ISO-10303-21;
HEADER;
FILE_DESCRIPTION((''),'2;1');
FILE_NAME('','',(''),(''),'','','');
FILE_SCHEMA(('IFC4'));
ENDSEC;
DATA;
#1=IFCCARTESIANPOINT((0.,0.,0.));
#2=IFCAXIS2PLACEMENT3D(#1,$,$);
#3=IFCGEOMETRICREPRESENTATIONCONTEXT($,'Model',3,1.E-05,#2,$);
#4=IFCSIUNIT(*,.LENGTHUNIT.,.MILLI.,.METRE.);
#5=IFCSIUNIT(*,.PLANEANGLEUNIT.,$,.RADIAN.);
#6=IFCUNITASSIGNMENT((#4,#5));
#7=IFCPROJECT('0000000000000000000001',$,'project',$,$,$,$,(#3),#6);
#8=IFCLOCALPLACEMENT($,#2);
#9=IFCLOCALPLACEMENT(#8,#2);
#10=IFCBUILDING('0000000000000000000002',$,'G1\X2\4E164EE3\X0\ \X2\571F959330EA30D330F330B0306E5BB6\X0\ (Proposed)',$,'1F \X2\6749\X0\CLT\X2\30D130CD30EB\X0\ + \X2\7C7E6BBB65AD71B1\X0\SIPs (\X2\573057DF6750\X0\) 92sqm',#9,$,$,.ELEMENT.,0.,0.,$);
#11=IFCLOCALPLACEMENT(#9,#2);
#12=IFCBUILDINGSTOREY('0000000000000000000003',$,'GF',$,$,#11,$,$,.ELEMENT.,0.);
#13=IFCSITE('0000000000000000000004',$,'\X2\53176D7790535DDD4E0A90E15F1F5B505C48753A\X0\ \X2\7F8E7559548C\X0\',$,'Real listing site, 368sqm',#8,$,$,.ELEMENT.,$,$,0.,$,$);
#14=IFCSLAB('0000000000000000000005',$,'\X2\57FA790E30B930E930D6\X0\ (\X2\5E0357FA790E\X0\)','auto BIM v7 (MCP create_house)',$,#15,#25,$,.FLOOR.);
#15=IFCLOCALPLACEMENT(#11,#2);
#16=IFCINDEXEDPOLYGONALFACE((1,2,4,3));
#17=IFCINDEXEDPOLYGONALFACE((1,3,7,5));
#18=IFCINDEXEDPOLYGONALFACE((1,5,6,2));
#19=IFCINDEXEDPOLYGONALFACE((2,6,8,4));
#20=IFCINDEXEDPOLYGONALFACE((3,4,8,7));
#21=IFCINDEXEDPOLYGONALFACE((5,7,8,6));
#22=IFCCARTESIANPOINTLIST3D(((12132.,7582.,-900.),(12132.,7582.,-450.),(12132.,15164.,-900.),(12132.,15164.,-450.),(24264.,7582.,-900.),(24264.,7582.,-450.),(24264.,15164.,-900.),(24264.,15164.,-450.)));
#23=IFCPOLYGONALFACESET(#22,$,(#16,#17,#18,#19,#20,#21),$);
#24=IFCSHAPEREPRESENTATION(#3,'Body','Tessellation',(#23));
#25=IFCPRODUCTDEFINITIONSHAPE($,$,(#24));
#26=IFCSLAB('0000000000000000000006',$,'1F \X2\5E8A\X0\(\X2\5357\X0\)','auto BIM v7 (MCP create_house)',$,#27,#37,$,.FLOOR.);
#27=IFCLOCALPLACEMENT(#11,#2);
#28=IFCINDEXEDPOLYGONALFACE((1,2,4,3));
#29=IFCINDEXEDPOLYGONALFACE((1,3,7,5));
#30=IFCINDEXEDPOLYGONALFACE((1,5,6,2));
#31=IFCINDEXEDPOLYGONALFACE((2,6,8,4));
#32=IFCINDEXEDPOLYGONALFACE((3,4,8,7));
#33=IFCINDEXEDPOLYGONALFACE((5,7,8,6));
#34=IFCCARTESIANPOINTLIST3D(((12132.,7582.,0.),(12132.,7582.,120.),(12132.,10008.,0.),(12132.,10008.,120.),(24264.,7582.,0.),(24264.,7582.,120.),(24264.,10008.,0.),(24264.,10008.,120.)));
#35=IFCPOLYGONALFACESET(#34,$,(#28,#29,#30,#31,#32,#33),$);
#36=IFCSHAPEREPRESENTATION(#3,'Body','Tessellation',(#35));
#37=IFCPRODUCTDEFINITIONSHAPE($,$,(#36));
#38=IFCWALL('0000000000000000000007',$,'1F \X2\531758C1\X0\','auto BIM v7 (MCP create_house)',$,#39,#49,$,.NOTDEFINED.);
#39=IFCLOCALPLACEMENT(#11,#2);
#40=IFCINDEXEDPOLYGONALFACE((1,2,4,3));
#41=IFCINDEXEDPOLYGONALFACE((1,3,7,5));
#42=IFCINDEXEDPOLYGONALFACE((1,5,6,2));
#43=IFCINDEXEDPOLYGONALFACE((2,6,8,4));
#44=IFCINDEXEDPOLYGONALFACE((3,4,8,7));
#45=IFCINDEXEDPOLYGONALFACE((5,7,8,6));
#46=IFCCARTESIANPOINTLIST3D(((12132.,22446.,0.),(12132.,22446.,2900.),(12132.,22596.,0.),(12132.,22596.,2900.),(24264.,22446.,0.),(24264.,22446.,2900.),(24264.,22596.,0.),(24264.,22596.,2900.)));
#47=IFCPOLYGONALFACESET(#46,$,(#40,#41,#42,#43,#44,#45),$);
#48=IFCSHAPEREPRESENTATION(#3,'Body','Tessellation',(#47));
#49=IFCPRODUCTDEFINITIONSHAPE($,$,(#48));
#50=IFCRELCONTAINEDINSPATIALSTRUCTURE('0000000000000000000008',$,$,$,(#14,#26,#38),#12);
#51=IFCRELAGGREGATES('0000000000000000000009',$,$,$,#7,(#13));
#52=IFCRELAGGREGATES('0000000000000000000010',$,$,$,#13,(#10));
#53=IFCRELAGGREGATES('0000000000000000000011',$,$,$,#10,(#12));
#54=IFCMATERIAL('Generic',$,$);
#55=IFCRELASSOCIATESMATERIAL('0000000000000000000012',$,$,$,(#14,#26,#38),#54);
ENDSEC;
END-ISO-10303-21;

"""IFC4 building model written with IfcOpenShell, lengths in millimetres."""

from ifc_helpers import new_model, si_unit, frame, frame_2d, origin, place, context, project, spatial, rectangle, extrude, material, element, save


model = new_model("IFC4")

# Units and contexts
model_context = context("Model", 3, precision=1e-05, world=origin())
ifc_project = project(units=[si_unit("LENGTHUNIT", "METRE", prefix="MILLI"), si_unit("PLANEANGLEUNIT", "RADIAN")], contexts=[model_context])

# Site, building, storey
site_placement = place(None, origin())
site = spatial("IfcSite", under=ifc_project, at=site_placement, Name="北海道川上郡弟子屈町 美留和", ObjectType="Real listing site, 368sqm", CompositionType="ELEMENT", RefElevation=0.0)
building_placement = place(site_placement, origin())
building = spatial("IfcBuilding", under=site, at=building_placement, Name="G1世代 土間リビングの家 (Proposed)", ObjectType="1F 杉CLTパネル + 籾殻断熱SIPs (地域材) 92sqm", CompositionType="ELEMENT", ElevationOfRefHeight=0.0, ElevationOfTerrain=0.0)
storey_placement = place(building_placement, origin())
storey = spatial("IfcBuildingStorey", under=building, at=storey_placement, Name="GF", CompositionType="ELEMENT", Elevation=0.0)

# Slabs
ifc_material = material(Name="Generic")
slab_1_placement = place(storey_placement, frame((6066.0, 3791.0, -450.0)))
element("IfcSlab", 1, at=slab_1_placement, inside=storey, material=ifc_material, Name="基礎スラブ (布基礎)", Description="auto BIM v7 (MCP create_house)", PredefinedType="FLOOR", context=model_context, shape_type="SweptSolid", body=[
    extrude(rectangle(XDim=12132.0, YDim=7582.0, at=frame_2d((6066.0, 3791.0))), frame((6066.0, 3791.0, -450.0)), (0.0, 0.0, 1.0), 450.0),
])
slab_2_placement = place(storey_placement, frame((6066.0, 3791.0, 0.0)))
element("IfcSlab", 2, at=slab_2_placement, inside=storey, material=ifc_material, Name="1F 床(南)", Description="auto BIM v7 (MCP create_house)", PredefinedType="FLOOR", context=model_context, shape_type="SweptSolid", body=[
    extrude(rectangle(XDim=12132.0, YDim=2426.0, at=frame_2d((6066.0, 1213.0))), frame((6066.0, 3791.0, 0.0)), (0.0, 0.0, 1.0), 120.0),
])

# Wall
wall_1_placement = place(storey_placement, frame((6066.0, 11223.0, 0.0)))
element("IfcWall", 3, at=wall_1_placement, inside=storey, material=ifc_material, Name="1F 北壁", Description="auto BIM v7 (MCP create_house)", PredefinedType="NOTDEFINED", context=model_context, shape_type="SweptSolid", body=[
    extrude(rectangle(XDim=12132.0, YDim=150.0, at=frame_2d((6066.0, 75.0))), frame((6066.0, 11223.0, 0.0)), (0.0, 0.0, 1.0), 2900.0),
])

save(model, "model.ifc")
